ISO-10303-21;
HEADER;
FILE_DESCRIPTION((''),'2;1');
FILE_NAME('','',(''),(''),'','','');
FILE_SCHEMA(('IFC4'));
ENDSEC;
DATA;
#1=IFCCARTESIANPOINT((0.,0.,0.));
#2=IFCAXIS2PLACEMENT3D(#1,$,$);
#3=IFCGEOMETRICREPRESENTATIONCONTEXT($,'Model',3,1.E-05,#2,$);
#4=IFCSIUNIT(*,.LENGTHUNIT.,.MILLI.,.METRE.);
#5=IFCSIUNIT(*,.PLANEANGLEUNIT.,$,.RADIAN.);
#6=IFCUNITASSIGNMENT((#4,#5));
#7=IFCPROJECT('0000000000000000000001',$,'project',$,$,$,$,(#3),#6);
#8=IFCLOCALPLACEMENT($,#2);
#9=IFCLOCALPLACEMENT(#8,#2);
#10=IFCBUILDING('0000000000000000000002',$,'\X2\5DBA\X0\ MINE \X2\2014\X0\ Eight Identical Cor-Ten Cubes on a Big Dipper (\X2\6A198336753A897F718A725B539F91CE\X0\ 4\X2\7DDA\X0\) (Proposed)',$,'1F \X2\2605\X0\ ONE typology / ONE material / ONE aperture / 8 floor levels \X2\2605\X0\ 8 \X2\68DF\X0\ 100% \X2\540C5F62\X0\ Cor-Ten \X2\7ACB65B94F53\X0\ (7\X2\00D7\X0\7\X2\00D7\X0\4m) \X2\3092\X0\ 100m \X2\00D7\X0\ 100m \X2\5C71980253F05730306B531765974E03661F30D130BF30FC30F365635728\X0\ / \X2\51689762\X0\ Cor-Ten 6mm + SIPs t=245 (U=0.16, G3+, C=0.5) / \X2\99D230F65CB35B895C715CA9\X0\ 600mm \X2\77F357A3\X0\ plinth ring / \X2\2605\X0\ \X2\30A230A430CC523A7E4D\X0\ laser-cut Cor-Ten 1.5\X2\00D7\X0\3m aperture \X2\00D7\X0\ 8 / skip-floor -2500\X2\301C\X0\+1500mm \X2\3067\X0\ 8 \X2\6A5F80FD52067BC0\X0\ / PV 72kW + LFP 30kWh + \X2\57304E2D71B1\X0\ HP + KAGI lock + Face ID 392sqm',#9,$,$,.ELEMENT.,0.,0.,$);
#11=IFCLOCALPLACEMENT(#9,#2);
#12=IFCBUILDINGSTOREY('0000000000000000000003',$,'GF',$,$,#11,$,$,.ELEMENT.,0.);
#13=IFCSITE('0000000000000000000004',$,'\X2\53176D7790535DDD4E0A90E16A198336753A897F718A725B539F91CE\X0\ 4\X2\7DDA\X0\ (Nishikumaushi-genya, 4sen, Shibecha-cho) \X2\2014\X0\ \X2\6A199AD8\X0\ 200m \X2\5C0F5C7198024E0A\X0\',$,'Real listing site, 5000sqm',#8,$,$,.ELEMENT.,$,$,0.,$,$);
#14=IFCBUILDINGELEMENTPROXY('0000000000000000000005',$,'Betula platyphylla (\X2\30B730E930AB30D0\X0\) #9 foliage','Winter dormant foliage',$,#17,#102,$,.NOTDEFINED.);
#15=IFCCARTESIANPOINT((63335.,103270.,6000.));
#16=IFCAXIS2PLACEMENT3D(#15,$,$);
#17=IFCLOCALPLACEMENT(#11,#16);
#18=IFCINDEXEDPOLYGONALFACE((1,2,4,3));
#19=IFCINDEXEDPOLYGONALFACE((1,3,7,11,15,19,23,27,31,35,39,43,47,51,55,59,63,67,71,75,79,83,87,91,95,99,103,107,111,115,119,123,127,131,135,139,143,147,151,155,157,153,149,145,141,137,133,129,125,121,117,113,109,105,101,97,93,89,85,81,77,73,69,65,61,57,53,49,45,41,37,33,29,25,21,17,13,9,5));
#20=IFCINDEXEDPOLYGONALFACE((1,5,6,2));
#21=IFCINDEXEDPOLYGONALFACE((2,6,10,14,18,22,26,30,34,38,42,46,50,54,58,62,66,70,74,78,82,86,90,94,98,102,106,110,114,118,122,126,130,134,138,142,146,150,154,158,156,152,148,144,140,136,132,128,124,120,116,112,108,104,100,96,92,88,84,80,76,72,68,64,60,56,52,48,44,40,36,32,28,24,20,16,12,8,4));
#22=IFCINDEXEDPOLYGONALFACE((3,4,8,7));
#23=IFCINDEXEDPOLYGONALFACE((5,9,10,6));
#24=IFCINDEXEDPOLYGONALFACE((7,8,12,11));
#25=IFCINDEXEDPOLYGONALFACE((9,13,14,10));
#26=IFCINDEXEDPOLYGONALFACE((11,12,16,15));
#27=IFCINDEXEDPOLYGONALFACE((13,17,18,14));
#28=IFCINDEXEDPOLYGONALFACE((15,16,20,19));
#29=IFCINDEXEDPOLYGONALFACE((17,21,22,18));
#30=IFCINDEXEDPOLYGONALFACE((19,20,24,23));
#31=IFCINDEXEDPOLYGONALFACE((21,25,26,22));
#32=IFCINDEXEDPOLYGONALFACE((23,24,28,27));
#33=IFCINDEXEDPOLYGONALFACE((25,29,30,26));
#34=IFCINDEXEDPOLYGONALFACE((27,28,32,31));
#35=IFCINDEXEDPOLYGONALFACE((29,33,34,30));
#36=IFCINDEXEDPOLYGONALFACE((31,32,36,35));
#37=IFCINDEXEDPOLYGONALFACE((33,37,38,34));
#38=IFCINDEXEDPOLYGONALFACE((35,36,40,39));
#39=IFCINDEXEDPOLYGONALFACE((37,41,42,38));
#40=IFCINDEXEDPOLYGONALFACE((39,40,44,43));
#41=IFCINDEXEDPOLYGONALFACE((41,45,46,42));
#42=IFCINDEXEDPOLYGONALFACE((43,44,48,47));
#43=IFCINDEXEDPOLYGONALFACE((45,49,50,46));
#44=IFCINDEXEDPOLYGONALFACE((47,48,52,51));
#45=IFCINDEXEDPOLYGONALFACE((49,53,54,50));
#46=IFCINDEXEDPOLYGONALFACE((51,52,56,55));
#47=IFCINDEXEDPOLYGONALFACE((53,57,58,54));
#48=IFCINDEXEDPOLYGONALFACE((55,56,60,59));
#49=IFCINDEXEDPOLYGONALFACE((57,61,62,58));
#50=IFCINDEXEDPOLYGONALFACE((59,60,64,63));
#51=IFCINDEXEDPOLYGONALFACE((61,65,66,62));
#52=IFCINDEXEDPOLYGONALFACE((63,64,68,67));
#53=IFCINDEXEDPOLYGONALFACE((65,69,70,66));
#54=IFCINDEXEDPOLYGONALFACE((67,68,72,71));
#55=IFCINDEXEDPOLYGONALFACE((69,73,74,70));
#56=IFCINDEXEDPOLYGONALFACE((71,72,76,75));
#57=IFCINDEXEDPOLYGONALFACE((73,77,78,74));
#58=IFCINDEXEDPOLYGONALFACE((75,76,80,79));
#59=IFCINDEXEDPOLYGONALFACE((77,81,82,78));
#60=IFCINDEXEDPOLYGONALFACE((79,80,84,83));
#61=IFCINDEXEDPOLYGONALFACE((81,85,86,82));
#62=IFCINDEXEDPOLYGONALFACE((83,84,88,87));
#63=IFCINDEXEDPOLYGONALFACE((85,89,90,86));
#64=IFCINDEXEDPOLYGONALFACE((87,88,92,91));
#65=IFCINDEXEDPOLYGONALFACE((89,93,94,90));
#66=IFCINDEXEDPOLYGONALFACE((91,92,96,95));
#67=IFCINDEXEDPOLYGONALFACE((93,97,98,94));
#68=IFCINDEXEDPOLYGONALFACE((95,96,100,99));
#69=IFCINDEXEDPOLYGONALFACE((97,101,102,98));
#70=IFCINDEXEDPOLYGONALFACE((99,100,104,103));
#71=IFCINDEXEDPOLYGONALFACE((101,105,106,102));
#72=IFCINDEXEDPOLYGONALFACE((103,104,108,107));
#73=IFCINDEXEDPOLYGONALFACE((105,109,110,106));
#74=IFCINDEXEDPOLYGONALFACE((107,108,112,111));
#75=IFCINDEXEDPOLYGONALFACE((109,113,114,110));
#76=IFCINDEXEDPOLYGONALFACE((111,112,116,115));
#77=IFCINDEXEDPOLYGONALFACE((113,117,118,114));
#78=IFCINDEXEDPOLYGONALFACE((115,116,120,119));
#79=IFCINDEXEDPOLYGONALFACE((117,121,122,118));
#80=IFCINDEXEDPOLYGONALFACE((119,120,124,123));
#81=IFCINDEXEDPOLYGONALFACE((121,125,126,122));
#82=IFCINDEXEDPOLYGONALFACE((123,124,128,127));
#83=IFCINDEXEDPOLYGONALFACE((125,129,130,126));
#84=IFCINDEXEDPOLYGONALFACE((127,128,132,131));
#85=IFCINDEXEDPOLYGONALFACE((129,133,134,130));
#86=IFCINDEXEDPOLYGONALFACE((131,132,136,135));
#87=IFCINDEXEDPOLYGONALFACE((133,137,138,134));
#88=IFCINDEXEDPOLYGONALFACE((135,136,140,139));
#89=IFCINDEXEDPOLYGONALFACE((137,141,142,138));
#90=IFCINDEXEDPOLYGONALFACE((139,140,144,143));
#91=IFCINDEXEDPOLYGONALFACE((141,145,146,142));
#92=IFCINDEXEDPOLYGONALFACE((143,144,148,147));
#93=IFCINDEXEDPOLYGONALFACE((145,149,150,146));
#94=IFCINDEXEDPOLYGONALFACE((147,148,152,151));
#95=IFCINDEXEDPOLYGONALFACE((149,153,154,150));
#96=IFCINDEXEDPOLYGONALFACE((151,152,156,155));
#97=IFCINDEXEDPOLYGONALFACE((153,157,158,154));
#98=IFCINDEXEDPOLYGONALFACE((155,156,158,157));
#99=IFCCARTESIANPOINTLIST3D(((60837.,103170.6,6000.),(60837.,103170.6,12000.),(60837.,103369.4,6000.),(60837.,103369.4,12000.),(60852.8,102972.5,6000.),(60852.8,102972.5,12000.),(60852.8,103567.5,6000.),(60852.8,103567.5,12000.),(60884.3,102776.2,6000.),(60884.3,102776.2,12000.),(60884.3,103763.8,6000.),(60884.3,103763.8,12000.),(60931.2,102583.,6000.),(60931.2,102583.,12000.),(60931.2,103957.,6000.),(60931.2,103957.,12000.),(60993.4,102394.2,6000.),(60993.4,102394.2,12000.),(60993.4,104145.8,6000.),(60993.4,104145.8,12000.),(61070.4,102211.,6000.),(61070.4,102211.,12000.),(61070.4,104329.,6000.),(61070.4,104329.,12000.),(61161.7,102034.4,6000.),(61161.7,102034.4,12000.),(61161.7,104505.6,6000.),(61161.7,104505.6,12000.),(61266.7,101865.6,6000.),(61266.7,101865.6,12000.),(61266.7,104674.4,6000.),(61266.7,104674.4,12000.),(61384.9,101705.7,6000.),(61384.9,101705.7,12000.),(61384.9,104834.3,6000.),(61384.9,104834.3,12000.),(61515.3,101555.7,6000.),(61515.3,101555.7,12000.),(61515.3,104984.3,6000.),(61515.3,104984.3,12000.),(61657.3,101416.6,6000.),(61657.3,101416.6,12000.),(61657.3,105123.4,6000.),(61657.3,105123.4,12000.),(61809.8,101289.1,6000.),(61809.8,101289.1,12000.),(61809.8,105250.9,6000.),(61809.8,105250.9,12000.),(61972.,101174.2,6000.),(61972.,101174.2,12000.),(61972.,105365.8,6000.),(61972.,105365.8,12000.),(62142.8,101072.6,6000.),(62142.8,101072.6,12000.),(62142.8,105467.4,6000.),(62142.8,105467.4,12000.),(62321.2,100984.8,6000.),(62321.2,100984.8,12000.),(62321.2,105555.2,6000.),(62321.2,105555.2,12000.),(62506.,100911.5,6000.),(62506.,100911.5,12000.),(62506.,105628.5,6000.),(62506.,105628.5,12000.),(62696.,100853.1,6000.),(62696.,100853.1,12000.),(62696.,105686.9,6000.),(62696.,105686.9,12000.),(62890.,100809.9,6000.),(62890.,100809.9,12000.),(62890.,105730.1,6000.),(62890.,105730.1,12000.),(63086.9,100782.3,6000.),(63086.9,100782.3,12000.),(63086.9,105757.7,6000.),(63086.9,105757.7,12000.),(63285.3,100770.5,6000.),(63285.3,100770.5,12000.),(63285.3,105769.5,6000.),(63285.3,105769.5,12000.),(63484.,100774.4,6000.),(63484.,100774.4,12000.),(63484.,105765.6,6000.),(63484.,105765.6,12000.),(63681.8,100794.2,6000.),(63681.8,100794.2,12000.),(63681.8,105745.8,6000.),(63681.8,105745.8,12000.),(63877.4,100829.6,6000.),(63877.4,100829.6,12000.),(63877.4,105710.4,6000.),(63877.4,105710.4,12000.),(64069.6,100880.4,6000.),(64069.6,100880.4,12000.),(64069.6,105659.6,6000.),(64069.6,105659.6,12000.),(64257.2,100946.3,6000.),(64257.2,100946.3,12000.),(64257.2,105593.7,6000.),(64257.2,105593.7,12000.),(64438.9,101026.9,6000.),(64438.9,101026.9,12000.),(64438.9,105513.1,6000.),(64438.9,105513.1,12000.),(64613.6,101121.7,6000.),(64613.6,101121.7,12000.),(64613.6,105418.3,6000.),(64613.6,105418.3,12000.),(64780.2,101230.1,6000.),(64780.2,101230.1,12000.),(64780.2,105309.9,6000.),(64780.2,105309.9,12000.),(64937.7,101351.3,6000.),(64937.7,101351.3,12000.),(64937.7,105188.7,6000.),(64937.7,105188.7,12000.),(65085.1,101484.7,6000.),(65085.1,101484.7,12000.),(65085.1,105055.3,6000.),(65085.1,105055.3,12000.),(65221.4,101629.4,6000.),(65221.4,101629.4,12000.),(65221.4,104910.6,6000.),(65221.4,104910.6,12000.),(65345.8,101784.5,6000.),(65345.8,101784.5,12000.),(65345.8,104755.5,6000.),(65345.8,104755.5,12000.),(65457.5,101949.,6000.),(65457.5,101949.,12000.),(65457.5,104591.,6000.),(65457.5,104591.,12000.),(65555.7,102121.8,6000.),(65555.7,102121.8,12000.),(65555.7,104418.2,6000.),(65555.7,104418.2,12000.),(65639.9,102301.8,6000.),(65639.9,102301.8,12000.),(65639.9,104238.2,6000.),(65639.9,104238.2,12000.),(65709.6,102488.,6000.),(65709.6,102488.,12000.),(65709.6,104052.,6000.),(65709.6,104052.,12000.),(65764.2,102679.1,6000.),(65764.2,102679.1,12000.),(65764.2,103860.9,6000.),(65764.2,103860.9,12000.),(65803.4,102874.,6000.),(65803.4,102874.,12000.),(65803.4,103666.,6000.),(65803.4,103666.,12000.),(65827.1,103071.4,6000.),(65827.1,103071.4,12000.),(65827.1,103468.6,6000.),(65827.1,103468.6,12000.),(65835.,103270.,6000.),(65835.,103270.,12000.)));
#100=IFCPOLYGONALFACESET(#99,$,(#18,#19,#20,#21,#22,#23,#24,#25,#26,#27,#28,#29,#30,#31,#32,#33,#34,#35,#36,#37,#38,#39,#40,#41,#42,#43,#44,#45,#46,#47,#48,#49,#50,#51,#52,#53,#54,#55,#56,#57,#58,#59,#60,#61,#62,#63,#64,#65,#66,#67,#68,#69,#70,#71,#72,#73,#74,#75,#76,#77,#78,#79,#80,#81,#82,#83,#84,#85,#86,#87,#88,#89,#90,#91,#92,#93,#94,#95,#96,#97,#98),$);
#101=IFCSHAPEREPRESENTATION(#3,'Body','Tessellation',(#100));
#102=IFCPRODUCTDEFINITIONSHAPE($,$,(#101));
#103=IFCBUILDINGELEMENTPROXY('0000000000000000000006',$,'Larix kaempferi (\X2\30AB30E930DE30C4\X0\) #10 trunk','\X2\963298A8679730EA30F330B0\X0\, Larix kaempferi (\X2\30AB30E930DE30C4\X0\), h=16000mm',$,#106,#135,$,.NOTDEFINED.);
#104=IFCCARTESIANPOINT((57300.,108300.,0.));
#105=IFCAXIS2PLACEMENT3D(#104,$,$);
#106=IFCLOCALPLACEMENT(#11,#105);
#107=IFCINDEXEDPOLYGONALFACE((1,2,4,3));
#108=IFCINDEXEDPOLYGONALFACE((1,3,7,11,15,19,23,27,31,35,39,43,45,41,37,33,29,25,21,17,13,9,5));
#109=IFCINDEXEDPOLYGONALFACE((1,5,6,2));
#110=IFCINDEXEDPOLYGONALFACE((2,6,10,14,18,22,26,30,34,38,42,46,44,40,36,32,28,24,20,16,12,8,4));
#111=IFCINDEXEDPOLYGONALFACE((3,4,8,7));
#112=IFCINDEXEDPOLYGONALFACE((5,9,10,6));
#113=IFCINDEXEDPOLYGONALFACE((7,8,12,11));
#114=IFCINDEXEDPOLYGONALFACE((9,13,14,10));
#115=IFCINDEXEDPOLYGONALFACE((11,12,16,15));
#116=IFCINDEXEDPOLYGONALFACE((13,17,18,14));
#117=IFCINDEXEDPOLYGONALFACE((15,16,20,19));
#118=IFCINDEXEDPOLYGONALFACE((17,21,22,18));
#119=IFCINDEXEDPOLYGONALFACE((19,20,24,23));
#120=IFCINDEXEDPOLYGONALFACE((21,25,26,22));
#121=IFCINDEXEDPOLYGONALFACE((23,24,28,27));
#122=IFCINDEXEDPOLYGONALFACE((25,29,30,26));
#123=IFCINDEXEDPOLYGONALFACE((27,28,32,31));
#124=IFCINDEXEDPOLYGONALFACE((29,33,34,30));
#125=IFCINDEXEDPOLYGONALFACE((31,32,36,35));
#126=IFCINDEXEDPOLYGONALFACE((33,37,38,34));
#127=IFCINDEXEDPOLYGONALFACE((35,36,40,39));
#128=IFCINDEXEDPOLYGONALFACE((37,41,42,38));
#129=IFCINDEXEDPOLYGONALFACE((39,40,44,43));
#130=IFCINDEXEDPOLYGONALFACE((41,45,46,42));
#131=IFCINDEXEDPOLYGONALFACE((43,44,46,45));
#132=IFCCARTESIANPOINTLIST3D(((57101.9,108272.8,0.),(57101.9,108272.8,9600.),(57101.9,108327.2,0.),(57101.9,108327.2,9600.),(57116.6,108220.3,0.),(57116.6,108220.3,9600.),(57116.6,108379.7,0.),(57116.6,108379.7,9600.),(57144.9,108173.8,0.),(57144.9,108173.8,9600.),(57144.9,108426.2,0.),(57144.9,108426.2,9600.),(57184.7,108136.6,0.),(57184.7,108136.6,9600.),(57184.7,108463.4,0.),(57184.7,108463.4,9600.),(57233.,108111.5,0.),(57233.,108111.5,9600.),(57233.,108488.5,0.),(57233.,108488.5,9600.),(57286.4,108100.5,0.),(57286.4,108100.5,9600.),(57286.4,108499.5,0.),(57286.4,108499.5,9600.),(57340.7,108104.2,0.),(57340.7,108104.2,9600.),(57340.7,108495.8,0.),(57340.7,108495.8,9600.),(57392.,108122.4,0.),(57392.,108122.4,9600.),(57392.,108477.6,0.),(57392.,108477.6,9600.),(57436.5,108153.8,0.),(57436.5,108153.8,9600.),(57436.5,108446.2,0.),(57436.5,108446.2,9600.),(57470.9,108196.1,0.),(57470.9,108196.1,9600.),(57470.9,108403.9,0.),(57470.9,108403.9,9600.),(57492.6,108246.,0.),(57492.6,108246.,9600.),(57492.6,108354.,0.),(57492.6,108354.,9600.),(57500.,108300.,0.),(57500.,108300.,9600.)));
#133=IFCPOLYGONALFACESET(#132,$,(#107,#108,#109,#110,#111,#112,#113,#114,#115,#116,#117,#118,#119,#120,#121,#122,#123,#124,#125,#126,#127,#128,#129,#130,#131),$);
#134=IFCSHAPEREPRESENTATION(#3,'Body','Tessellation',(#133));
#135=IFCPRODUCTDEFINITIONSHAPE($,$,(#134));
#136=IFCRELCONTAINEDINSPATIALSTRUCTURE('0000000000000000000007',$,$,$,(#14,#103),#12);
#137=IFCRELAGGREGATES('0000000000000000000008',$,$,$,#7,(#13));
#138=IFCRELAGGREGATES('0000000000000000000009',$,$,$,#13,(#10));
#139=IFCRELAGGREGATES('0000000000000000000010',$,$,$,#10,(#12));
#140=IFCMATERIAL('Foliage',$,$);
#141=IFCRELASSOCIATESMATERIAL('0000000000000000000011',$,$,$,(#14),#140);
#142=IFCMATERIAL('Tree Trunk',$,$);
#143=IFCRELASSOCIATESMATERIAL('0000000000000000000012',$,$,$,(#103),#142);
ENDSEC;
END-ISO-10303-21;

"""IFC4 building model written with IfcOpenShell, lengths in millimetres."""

from ifc_helpers import new_model, si_unit, frame, origin, origin_2d, place, context, project, spatial, circle, extrude, material, element, save


model = new_model("IFC4")

# Units and contexts
model_context = context("Model", 3, precision=1e-05, world=origin())
ifc_project = project(units=[si_unit("LENGTHUNIT", "METRE", prefix="MILLI"), si_unit("PLANEANGLEUNIT", "RADIAN")], contexts=[model_context])

# Site, building, storey
site_placement = place(None, origin())
site = spatial("IfcSite", under=ifc_project, at=site_placement, Name="北海道川上郡標茶町西熊牛原野 4線 (Nishikumaushi-genya, 4sen, Shibecha-cho) — 標高 200m 小山頂上", ObjectType="Real listing site, 5000sqm", CompositionType="ELEMENT", RefElevation=0.0)
building_placement = place(site_placement, origin())
building = spatial("IfcBuilding", under=site, at=building_placement, Name="嶺 MINE — Eight Identical Cor-Ten Cubes on a Big Dipper (標茶町西熊牛原野 4線) (Proposed)", ObjectType="1F ★ ONE typology / ONE material / ONE aperture / 8 floor levels ★ 8 棟 100% 同形 Cor-Ten 立方体 (7×7×4m) を 100m × 100m 山頂台地に北斗七星パターン散在 / 全面 Cor-Ten 6mm + SIPs t=245 (U=0.16, G3+, C=0.5) / 駒ヶ岳安山岩 600mm 石垣 plinth ring / ★ アイヌ刺繍 laser-cut Cor-Ten 1.5×3m aperture × 8 / skip-floor -2500〜+1500mm で 8 機能分節 / PV 72kW + LFP 30kWh + 地中熱 HP + KAGI lock + Face ID 392sqm", CompositionType="ELEMENT", ElevationOfRefHeight=0.0, ElevationOfTerrain=0.0)
storey_placement = place(building_placement, origin())
storey = spatial("IfcBuildingStorey", under=building, at=storey_placement, Name="GF", CompositionType="ELEMENT", Elevation=0.0)

# Building element proxies
ifc_material_1 = material(Name="Tree Trunk")
ifc_material_2 = material(Name="Foliage")
proxy_1_placement = place(storey_placement, frame((63335.0, 103270.0, 6000.0)))
element("IfcBuildingElementProxy", 1, at=proxy_1_placement, inside=storey, material=ifc_material_2, Name="Betula platyphylla (シラカバ) #9 foliage", Description="Winter dormant foliage", PredefinedType="NOTDEFINED", context=model_context, shape_type="SweptSolid", body=[
    extrude(circle(Radius=2500.0, at=origin_2d()), frame((63335.0, 103270.0, 6000.0)), (0.0, 0.0, 1.0), 6000.0),
])
proxy_2_placement = place(storey_placement, frame((57300.0, 108300.0, 0.0)))
element("IfcBuildingElementProxy", 2, at=proxy_2_placement, inside=storey, material=ifc_material_1, Name="Larix kaempferi (カラマツ) #10 trunk", Description="防風林リング, Larix kaempferi (カラマツ), h=16000mm", PredefinedType="NOTDEFINED", context=model_context, shape_type="SweptSolid", body=[
    extrude(circle(Radius=200.0, at=origin_2d()), frame((57300.0, 108300.0, 0.0)), (0.0, 0.0, 1.0), 9600.0),
])

save(model, "model.ifc")
